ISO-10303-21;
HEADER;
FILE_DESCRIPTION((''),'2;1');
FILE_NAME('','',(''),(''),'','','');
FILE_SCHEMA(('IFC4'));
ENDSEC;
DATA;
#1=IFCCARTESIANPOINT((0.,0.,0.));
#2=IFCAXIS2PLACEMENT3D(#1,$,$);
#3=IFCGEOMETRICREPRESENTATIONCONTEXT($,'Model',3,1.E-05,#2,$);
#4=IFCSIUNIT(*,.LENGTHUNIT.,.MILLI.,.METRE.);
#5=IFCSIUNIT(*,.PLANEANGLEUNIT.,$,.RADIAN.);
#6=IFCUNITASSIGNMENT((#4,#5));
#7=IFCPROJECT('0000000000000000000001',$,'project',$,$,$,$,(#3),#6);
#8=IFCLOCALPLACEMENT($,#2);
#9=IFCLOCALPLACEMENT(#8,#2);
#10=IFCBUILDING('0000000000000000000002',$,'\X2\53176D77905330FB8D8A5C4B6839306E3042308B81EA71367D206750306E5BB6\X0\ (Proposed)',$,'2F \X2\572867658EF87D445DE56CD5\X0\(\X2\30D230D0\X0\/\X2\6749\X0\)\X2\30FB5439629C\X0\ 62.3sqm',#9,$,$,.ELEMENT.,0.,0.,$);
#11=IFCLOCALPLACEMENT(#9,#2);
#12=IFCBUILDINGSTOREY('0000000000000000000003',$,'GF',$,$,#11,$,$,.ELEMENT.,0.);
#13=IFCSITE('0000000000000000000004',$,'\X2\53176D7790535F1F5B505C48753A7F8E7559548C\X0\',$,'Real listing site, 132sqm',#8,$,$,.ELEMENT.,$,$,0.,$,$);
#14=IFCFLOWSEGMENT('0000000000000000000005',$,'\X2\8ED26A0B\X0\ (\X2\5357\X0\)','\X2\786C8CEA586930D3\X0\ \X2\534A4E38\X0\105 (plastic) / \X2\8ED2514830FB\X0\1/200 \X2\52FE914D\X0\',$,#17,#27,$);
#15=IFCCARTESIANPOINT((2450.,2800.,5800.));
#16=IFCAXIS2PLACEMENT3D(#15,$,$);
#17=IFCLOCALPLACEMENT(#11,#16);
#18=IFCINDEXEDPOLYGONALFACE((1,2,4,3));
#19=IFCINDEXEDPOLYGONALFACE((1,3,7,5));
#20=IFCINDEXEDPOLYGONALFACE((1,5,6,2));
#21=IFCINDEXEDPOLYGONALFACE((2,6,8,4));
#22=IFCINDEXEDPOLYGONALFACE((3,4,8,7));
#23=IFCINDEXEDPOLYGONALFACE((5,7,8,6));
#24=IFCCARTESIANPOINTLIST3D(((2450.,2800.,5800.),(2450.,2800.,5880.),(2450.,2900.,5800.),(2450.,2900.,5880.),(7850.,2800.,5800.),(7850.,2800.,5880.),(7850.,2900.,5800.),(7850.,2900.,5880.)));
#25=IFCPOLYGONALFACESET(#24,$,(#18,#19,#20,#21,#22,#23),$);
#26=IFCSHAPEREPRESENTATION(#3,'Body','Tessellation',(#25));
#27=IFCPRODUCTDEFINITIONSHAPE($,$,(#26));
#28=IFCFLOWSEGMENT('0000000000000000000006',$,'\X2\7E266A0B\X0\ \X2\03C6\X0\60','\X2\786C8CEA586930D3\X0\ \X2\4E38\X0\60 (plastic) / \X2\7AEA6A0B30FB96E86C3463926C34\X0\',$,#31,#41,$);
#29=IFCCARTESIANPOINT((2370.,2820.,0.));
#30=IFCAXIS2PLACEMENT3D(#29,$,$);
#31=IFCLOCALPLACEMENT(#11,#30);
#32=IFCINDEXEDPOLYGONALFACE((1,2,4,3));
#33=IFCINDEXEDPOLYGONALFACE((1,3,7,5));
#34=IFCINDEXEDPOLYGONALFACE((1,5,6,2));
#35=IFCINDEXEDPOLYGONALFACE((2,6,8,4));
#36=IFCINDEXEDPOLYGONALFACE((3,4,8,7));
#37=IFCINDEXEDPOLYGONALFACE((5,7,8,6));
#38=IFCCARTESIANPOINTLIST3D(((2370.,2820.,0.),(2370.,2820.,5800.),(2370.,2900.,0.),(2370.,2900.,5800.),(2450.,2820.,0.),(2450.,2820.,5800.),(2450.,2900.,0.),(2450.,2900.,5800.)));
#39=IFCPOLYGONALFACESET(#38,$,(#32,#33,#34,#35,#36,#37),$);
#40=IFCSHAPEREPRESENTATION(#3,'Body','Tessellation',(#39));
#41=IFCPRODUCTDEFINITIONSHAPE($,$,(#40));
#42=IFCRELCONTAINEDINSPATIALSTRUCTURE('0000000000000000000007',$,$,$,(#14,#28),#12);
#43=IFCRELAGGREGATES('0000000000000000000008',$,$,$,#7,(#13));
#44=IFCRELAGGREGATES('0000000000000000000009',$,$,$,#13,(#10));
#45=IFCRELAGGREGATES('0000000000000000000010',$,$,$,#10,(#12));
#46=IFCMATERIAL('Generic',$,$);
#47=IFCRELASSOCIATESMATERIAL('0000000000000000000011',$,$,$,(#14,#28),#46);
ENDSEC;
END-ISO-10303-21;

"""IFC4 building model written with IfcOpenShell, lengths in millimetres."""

from ifc_helpers import new_model, si_unit, frame, frame_2d, origin, place, context, project, spatial, rectangle, extrude, material, element, save


model = new_model("IFC4")

# Units and contexts
model_context = context("Model", 3, precision=1e-05, world=origin())
ifc_project = project(units=[si_unit("LENGTHUNIT", "METRE", prefix="MILLI"), si_unit("PLANEANGLEUNIT", "RADIAN")], contexts=[model_context])

# Site, building, storey
site_placement = place(None, origin())
site = spatial("IfcSite", under=ifc_project, at=site_placement, Name="北海道弟子屈町美留和", ObjectType="Real listing site, 132sqm", CompositionType="ELEMENT", RefElevation=0.0)
building_placement = place(site_placement, origin())
building = spatial("IfcBuilding", under=site, at=building_placement, Name="北海道・越屋根のある自然素材の家 (Proposed)", ObjectType="2F 在来軸組工法(ヒバ/杉)・吹抜 62.3sqm", CompositionType="ELEMENT", ElevationOfRefHeight=0.0, ElevationOfTerrain=0.0)
storey_placement = place(building_placement, origin())
storey = spatial("IfcBuildingStorey", under=building, at=storey_placement, Name="GF", CompositionType="ELEMENT", Elevation=0.0)

# Flow segments
ifc_material_1 = material(Name="Generic")
flow_segment_1_placement = place(storey_placement, frame((2450.0, 2800.0, 5800.0)))
element("IfcFlowSegment", 1, at=flow_segment_1_placement, inside=storey, material=ifc_material_1, Name="軒樋 (南)", Description="硬質塩ビ 半丸105 (plastic) / 軒先・1/200 勾配", context=model_context, shape_type="SweptSolid", body=[
    extrude(rectangle(XDim=5400.0, YDim=100.0, at=frame_2d((2700.0, 50.0))), frame((2450.0, 2800.0, 5800.0)), (0.0, 0.0, 1.0), 80.0),
])
flow_segment_2_placement = place(storey_placement, frame((2370.0, 2820.0, 0.0)))
element("IfcFlowSegment", 2, at=flow_segment_2_placement, inside=storey, material=ifc_material_1, Name="縦樋 φ60", Description="硬質塩ビ 丸60 (plastic) / 竪樋・雨水排水", context=model_context, shape_type="SweptSolid", body=[
    extrude(rectangle(XDim=80.0, YDim=80.0, at=frame_2d((40.0, 40.0))), frame((2370.0, 2820.0, 0.0)), (0.0, 0.0, 1.0), 5800.0),
])

save(model, "model.ifc")
